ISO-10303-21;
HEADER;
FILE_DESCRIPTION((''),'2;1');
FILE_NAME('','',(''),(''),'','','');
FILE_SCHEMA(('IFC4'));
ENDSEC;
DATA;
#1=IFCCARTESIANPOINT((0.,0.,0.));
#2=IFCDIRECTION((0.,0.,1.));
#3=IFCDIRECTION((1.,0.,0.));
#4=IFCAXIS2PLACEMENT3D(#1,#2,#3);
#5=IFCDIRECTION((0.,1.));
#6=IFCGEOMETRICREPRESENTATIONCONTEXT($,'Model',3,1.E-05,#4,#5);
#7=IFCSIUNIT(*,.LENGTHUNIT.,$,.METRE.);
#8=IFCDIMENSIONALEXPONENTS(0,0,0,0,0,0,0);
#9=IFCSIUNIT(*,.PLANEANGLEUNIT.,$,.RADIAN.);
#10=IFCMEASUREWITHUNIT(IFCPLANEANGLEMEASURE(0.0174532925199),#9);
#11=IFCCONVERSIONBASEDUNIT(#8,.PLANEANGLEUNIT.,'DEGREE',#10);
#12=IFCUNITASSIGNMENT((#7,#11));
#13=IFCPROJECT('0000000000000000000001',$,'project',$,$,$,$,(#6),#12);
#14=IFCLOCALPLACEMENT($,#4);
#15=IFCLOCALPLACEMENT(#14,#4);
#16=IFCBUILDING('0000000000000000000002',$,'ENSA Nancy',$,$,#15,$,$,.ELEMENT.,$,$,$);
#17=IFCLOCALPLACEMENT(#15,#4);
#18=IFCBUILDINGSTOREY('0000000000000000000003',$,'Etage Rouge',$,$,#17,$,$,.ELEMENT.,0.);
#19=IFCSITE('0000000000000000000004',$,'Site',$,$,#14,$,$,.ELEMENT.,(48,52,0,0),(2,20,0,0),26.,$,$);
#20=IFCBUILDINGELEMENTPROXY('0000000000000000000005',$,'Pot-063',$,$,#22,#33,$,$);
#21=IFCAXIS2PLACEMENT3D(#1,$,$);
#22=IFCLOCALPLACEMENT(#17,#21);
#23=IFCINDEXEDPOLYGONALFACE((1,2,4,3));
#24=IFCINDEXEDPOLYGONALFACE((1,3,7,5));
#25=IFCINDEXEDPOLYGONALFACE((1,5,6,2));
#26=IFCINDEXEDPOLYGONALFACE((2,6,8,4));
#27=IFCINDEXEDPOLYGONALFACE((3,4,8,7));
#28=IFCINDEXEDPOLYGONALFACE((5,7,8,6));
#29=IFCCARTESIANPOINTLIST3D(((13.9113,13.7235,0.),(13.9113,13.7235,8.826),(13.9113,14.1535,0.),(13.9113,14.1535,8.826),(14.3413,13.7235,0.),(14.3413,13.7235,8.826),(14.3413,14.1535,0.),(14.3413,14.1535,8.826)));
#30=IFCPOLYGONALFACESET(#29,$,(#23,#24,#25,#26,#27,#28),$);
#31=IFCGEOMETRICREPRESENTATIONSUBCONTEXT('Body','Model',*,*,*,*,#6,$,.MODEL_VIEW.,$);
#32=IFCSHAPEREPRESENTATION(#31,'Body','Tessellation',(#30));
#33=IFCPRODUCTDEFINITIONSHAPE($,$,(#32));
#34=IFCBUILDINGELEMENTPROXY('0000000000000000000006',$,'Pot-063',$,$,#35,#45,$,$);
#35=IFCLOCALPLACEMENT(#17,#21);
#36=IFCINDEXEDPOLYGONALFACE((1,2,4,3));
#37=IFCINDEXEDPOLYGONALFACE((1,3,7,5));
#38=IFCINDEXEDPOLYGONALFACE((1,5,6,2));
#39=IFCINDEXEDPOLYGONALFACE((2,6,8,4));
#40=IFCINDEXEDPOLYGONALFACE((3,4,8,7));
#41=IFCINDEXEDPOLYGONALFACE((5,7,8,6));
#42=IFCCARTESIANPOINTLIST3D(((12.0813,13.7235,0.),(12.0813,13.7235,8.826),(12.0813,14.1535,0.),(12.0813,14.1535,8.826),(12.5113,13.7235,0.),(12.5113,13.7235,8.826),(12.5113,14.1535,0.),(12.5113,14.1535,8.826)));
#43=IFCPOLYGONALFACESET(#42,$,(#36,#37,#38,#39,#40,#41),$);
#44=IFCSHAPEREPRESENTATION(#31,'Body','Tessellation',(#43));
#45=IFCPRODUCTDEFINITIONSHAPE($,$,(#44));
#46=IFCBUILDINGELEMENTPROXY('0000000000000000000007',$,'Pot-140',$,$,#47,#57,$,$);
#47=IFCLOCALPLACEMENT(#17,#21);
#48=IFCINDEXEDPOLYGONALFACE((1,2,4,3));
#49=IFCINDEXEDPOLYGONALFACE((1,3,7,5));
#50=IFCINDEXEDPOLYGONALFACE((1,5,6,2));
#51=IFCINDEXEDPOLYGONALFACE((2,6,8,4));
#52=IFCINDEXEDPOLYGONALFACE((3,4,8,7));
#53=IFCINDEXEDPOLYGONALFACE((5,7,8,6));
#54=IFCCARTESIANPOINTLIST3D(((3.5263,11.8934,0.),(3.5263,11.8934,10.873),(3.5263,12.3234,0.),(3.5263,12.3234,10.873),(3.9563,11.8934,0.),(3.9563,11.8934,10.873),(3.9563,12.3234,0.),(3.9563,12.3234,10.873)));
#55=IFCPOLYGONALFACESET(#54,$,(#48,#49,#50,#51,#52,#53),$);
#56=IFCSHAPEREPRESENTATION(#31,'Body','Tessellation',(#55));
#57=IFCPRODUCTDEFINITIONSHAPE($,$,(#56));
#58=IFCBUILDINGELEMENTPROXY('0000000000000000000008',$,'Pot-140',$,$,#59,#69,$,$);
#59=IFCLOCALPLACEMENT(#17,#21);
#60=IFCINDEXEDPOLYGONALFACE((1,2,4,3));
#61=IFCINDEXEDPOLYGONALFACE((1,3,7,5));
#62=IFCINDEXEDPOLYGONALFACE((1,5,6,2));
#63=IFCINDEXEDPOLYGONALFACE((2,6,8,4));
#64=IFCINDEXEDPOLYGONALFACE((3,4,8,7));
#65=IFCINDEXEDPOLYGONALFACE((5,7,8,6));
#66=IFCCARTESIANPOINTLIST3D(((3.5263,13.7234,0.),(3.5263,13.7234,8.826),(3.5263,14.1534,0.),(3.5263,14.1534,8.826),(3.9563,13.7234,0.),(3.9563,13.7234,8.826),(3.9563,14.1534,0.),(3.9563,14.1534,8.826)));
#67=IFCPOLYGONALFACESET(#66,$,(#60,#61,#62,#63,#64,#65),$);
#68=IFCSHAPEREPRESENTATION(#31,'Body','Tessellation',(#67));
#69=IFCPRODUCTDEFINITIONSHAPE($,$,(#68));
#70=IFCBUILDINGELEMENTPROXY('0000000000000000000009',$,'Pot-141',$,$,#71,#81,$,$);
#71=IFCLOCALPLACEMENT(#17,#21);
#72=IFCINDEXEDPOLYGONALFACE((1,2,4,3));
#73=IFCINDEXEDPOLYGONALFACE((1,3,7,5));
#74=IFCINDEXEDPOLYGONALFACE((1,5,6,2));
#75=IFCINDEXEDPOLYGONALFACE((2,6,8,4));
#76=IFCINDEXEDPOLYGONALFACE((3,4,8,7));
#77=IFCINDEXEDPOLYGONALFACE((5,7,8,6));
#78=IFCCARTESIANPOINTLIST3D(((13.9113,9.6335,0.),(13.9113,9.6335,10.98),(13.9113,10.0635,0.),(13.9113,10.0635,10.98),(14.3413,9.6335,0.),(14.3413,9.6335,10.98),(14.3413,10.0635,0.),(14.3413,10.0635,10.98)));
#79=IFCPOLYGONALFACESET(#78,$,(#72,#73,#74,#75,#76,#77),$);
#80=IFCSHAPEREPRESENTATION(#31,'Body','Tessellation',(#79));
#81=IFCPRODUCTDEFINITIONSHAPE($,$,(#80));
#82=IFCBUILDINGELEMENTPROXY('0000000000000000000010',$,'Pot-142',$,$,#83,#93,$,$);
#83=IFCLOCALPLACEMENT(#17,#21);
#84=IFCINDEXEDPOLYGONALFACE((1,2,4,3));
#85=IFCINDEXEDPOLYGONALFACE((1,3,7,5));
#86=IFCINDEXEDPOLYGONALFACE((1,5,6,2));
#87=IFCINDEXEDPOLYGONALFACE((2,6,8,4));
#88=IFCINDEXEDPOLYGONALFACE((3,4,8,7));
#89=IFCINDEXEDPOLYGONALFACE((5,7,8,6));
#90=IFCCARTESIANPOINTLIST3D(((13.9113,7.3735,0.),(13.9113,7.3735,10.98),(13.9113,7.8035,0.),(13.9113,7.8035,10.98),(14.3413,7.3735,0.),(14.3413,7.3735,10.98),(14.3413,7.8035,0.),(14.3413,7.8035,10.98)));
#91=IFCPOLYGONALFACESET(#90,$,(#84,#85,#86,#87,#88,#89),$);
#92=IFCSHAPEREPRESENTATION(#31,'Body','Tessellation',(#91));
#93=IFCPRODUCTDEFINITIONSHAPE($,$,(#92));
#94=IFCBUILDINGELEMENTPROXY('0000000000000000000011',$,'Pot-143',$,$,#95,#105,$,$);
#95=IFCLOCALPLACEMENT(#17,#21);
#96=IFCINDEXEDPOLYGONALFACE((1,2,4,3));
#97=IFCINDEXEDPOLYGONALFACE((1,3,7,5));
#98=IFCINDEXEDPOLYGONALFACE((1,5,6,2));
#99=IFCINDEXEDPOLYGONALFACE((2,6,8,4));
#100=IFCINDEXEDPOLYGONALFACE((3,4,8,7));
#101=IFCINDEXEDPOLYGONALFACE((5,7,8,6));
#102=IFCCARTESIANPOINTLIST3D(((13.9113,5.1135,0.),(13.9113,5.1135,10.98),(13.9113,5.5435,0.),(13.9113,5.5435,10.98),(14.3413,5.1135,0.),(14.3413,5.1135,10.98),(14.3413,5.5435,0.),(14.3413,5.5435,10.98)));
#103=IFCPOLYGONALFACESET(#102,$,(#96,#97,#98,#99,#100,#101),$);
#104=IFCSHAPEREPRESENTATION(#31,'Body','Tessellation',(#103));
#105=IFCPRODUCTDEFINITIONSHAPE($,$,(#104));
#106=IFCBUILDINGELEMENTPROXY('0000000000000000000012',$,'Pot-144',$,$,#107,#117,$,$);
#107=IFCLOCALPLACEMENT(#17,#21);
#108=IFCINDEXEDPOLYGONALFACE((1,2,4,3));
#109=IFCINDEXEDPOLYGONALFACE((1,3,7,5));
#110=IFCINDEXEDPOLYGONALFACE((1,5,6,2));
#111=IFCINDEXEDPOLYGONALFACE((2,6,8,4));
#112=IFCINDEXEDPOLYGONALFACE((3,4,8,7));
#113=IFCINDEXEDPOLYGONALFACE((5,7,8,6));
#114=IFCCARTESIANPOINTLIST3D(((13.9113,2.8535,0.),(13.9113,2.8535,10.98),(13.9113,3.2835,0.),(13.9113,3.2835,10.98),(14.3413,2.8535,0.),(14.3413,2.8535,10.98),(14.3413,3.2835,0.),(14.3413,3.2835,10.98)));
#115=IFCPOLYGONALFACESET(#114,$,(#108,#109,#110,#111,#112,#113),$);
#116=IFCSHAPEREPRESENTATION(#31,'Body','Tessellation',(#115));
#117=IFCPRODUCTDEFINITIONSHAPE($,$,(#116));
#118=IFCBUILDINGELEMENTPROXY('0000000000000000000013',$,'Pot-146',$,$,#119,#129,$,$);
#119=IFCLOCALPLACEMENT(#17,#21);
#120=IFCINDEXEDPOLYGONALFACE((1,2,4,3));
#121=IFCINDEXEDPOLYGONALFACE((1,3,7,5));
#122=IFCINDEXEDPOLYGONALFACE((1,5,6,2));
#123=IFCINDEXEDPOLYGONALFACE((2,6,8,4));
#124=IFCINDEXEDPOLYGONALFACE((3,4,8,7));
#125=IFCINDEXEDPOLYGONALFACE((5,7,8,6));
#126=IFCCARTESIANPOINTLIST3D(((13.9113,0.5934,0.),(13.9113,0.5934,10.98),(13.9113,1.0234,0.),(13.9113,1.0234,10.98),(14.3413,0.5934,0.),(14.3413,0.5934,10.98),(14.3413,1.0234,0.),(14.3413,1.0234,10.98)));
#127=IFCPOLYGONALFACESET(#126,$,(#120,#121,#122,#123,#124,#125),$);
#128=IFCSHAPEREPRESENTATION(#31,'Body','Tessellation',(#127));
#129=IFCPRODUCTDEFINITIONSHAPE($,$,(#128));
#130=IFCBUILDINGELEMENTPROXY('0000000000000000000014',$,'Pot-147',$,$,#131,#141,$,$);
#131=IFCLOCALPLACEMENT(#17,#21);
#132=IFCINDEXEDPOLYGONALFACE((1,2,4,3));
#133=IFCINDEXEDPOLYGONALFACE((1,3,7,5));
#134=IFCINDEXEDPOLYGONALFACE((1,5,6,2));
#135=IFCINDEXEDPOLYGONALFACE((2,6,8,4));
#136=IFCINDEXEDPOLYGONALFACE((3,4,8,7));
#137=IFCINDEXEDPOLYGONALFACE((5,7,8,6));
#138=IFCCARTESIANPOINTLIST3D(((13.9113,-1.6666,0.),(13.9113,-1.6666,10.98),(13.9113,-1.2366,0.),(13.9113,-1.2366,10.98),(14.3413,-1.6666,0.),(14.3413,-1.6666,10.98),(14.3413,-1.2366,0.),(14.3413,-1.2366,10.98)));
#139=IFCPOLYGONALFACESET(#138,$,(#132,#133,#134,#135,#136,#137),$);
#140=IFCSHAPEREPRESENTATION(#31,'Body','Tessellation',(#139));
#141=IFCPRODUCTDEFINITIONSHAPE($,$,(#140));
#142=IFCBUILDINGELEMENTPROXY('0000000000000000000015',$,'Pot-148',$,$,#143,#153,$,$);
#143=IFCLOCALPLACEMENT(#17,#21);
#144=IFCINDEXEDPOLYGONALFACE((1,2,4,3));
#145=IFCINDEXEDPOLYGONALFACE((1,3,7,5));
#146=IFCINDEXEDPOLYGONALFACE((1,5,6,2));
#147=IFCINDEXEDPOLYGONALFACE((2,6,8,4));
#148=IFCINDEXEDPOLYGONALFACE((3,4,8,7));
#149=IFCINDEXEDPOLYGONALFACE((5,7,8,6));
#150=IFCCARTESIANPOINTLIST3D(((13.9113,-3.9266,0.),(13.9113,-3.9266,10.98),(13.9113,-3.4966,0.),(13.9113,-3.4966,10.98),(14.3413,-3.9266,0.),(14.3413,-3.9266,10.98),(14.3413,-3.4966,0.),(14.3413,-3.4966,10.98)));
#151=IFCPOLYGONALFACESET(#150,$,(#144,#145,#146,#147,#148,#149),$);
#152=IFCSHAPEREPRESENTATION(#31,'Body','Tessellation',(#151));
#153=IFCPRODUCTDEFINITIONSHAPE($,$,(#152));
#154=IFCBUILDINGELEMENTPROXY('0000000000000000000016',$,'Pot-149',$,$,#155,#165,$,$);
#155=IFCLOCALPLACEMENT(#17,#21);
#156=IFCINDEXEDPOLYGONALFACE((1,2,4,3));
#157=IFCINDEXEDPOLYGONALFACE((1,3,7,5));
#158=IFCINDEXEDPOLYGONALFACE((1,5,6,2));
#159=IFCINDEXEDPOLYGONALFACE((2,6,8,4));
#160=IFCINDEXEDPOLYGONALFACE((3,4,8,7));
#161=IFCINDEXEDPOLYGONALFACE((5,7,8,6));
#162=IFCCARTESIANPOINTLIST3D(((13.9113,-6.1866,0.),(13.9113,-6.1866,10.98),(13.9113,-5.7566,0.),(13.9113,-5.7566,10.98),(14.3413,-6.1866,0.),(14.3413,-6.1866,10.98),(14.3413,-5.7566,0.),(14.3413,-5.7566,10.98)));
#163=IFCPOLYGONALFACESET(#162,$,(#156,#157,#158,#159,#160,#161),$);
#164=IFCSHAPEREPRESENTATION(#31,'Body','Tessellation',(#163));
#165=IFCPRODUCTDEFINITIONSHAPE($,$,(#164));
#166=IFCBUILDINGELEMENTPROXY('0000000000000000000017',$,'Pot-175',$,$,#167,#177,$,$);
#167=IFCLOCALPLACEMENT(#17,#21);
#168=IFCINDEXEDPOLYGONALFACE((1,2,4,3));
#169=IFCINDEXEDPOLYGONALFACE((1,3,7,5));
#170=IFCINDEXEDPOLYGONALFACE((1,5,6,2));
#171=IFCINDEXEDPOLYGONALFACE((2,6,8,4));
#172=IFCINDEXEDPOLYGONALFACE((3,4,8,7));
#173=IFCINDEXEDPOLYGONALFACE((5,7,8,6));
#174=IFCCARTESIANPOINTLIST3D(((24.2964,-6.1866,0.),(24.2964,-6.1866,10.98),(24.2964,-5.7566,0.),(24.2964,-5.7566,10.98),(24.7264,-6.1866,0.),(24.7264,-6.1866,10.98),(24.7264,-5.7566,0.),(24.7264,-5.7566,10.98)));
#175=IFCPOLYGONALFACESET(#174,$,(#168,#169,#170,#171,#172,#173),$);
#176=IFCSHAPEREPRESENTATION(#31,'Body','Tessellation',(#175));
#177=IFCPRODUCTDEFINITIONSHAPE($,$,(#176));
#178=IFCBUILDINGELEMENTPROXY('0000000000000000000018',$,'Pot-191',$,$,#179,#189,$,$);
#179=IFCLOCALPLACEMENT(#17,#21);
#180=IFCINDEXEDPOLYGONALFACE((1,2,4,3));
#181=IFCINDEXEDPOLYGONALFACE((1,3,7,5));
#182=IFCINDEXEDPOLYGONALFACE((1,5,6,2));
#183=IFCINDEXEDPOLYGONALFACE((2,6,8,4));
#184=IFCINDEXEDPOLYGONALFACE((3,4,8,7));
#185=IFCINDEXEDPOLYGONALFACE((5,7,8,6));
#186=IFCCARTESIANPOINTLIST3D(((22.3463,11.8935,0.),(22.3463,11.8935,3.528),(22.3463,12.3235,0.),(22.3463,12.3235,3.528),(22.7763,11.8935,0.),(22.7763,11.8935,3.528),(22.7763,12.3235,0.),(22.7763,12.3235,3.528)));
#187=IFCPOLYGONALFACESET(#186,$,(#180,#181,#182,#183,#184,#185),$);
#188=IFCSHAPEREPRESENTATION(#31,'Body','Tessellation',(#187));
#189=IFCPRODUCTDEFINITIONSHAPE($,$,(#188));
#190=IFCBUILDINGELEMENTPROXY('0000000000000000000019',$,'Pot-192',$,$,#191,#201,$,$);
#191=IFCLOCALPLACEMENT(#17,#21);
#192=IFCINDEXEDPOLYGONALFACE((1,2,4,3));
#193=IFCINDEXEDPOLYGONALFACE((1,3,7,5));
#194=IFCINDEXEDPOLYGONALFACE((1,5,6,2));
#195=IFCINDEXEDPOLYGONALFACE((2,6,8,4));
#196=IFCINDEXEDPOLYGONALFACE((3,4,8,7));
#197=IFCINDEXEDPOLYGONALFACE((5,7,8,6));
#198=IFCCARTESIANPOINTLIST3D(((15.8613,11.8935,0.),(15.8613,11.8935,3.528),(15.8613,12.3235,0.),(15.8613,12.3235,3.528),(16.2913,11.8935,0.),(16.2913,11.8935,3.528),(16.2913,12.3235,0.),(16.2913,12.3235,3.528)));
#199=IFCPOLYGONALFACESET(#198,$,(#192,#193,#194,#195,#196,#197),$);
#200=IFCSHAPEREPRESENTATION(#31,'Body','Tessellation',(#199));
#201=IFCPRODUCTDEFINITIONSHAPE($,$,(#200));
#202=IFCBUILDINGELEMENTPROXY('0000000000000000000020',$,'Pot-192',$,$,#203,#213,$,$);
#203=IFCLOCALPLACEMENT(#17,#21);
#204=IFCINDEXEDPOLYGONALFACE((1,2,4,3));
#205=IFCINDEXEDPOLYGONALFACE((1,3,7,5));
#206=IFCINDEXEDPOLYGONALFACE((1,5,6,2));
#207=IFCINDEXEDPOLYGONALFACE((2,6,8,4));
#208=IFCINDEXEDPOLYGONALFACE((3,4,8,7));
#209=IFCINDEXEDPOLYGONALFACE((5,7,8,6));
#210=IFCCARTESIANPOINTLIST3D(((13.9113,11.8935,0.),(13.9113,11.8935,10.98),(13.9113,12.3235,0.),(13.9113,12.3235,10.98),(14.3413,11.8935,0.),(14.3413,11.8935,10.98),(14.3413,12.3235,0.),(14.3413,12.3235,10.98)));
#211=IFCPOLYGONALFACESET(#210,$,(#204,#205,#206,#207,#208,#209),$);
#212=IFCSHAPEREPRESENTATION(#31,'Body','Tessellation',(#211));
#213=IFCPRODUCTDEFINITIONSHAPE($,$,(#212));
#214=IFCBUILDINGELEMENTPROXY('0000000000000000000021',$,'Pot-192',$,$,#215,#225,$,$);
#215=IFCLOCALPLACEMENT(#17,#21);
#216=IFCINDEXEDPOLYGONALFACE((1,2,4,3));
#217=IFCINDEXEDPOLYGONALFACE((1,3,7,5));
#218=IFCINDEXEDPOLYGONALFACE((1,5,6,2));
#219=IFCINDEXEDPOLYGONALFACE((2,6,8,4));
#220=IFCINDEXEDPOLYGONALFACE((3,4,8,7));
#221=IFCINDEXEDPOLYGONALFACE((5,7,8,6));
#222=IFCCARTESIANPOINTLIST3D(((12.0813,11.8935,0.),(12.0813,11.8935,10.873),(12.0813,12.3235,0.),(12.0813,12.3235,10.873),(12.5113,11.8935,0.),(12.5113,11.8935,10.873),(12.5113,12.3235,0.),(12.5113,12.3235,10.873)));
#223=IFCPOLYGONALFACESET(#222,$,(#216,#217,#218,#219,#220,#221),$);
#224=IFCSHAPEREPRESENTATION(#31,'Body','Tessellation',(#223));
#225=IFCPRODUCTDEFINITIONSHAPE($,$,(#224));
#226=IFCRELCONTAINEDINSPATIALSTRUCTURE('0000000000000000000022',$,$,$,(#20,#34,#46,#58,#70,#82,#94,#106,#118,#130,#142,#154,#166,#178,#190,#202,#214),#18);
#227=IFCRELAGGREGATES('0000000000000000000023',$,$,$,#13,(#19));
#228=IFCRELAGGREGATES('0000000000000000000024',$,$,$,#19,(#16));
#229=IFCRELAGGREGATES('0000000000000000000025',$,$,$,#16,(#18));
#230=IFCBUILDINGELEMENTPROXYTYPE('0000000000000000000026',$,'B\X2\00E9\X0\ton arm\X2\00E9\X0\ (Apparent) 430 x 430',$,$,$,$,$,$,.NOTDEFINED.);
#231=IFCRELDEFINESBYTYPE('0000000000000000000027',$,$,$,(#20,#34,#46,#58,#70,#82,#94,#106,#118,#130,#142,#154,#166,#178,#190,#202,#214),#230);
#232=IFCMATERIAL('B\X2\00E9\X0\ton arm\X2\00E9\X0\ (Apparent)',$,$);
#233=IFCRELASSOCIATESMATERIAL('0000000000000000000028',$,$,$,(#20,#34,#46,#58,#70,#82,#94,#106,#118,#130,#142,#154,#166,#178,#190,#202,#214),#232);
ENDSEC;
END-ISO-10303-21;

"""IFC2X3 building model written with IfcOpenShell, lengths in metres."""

from ifc_helpers import new_model, entity, si_unit, converted_unit, direction, frame, origin_with_axes, origin_2d_with_axis, place, context, subcontext, project, spatial, rectangle, extrude, material, type_object, element, save


model = new_model("IFC2X3")

# Units and contexts
model_context = context("Model", 3, precision=1e-05, world=origin_with_axes(), true_north=direction((0.0, 1.0)))
body_context = subcontext(model_context, "Body", "Model", "MODEL_VIEW")
ifc_project = project(units=[si_unit("LENGTHUNIT", "METRE"), converted_unit("PLANEANGLEUNIT", "DEGREE", entity("IfcPlaneAngleMeasure", 0.0174532925199), si_unit("PLANEANGLEUNIT", "RADIAN"), dimensions=[0, 0, 0, 0, 0, 0, 0])], contexts=[model_context])

# Site, building, storey
site_placement = place(None, origin_with_axes())
site = spatial("IfcSite", under=ifc_project, at=site_placement, Name="Site", CompositionType="ELEMENT", RefLatitude=(48, 52, 0, 0), RefLongitude=(2, 20, 0, 0), RefElevation=26.0)
building_placement = place(site_placement, origin_with_axes())
building = spatial("IfcBuilding", under=site, at=building_placement, Name="ENSA Nancy", CompositionType="ELEMENT")
storey_placement = place(building_placement, origin_with_axes())
storey = spatial("IfcBuildingStorey", under=building, at=storey_placement, Name="Etage Rouge", CompositionType="ELEMENT", Elevation=0.0)

# Building element proxies
ifc_material_1 = material(Name="Béton armé (Apparent)")
building_element_proxy_type_1 = type_object("IfcBuildingElementProxyType", Name="Béton armé (Apparent) 430 x 430", PredefinedType="NOTDEFINED")
for number, where, z_axis, x_axis, name in (
    (1, (14.1263, 13.9385, 0.0), (0.0, 0.0, 1.0), (1.0, 0.0, 0.0), "Pot-063"),
    (2, (12.2963, 13.9385, 0.0), (0.0, 0.0, 1.0), (1.0, 0.0, 0.0), "Pot-063"),
):
    element("IfcBuildingElementProxy", number, at=place(storey_placement, frame(where, z_axis=z_axis, x_axis=x_axis)), inside=storey, type_object=building_element_proxy_type_1, material=ifc_material_1, Name=name, context=body_context, shape_type="SweptSolid", body=[
        extrude(rectangle(XDim=0.43, YDim=0.43, at=origin_2d_with_axis()), origin_with_axes(), (0.0, 0.0, 1.0), 8.826),
    ])
proxy_1_placement = place(storey_placement, frame((3.7413, 12.1084, 0.0), z_axis=(0.0, 0.0, 1.0), x_axis=(1.0, 0.0, 0.0)))
element("IfcBuildingElementProxy", 3, at=proxy_1_placement, inside=storey, type_object=building_element_proxy_type_1, material=ifc_material_1, Name="Pot-140", context=body_context, shape_type="SweptSolid", body=[
    extrude(rectangle(XDim=0.43, YDim=0.43, at=origin_2d_with_axis()), origin_with_axes(), (0.0, 0.0, 1.0), 10.873),
])
proxy_2_placement = place(storey_placement, frame((3.7413, 13.9384, 0.0), z_axis=(0.0, 0.0, 1.0), x_axis=(1.0, 0.0, 0.0)))
element("IfcBuildingElementProxy", 4, at=proxy_2_placement, inside=storey, type_object=building_element_proxy_type_1, material=ifc_material_1, Name="Pot-140", context=body_context, shape_type="SweptSolid", body=[
    extrude(rectangle(XDim=0.43, YDim=0.43, at=origin_2d_with_axis()), origin_with_axes(), (0.0, 0.0, 1.0), 8.826),
])
for number, where, z_axis, x_axis, name in (
    (5, (14.1263, 9.8485, 0.0), (0.0, 0.0, 1.0), (1.0, 0.0, 0.0), "Pot-141"),
    (6, (14.1263, 7.5885, 0.0), (0.0, 0.0, 1.0), (1.0, 0.0, 0.0), "Pot-142"),
    (7, (14.1263, 5.3285, 0.0), (0.0, 0.0, 1.0), (1.0, 0.0, 0.0), "Pot-143"),
    (8, (14.1263, 3.0685, 0.0), (0.0, 0.0, 1.0), (1.0, 0.0, 0.0), "Pot-144"),
    (9, (14.1263, 0.8084, 0.0), (0.0, 0.0, 1.0), (1.0, 0.0, 0.0), "Pot-146"),
    (10, (14.1263, -1.4516, 0.0), (0.0, 0.0, 1.0), (1.0, 0.0, 0.0), "Pot-147"),
    (11, (14.1263, -3.7116, 0.0), (0.0, 0.0, 1.0), (1.0, 0.0, 0.0), "Pot-148"),
    (12, (14.1263, -5.9716, 0.0), (0.0, 0.0, 1.0), (1.0, 0.0, 0.0), "Pot-149"),
    (13, (24.5114, -5.9716, 0.0), (0.0, 0.0, 1.0), (1.0, 0.0, 0.0), "Pot-175"),
):
    element("IfcBuildingElementProxy", number, at=place(storey_placement, frame(where, z_axis=z_axis, x_axis=x_axis)), inside=storey, type_object=building_element_proxy_type_1, material=ifc_material_1, Name=name, context=body_context, shape_type="SweptSolid", body=[
        extrude(rectangle(XDim=0.43, YDim=0.43, at=origin_2d_with_axis()), origin_with_axes(), (0.0, 0.0, 1.0), 10.98),
    ])
for number, where, z_axis, x_axis, name in (
    (14, (22.5613, 12.1085, 0.0), (0.0, 0.0, 1.0), (1.0, 0.0, 0.0), "Pot-191"),
    (15, (16.0763, 12.1085, 0.0), (0.0, 0.0, 1.0), (1.0, 0.0, 0.0), "Pot-192"),
):
    element("IfcBuildingElementProxy", number, at=place(storey_placement, frame(where, z_axis=z_axis, x_axis=x_axis)), inside=storey, type_object=building_element_proxy_type_1, material=ifc_material_1, Name=name, context=body_context, shape_type="SweptSolid", body=[
        extrude(rectangle(XDim=0.43, YDim=0.43, at=origin_2d_with_axis()), origin_with_axes(), (0.0, 0.0, 1.0), 3.528),
    ])
proxy_3_placement = place(storey_placement, frame((14.1263, 12.1085, 0.0), z_axis=(0.0, 0.0, 1.0), x_axis=(1.0, 0.0, 0.0)))
element("IfcBuildingElementProxy", 16, at=proxy_3_placement, inside=storey, type_object=building_element_proxy_type_1, material=ifc_material_1, Name="Pot-192", context=body_context, shape_type="SweptSolid", body=[
    extrude(rectangle(XDim=0.43, YDim=0.43, at=origin_2d_with_axis()), origin_with_axes(), (0.0, 0.0, 1.0), 10.98),
])
proxy_4_placement = place(storey_placement, frame((12.2963, 12.1085, 0.0), z_axis=(0.0, 0.0, 1.0), x_axis=(1.0, 0.0, 0.0)))
element("IfcBuildingElementProxy", 17, at=proxy_4_placement, inside=storey, type_object=building_element_proxy_type_1, material=ifc_material_1, Name="Pot-192", context=body_context, shape_type="SweptSolid", body=[
    extrude(rectangle(XDim=0.43, YDim=0.43, at=origin_2d_with_axis()), origin_with_axes(), (0.0, 0.0, 1.0), 10.873),
])

save(model, "model.ifc")
